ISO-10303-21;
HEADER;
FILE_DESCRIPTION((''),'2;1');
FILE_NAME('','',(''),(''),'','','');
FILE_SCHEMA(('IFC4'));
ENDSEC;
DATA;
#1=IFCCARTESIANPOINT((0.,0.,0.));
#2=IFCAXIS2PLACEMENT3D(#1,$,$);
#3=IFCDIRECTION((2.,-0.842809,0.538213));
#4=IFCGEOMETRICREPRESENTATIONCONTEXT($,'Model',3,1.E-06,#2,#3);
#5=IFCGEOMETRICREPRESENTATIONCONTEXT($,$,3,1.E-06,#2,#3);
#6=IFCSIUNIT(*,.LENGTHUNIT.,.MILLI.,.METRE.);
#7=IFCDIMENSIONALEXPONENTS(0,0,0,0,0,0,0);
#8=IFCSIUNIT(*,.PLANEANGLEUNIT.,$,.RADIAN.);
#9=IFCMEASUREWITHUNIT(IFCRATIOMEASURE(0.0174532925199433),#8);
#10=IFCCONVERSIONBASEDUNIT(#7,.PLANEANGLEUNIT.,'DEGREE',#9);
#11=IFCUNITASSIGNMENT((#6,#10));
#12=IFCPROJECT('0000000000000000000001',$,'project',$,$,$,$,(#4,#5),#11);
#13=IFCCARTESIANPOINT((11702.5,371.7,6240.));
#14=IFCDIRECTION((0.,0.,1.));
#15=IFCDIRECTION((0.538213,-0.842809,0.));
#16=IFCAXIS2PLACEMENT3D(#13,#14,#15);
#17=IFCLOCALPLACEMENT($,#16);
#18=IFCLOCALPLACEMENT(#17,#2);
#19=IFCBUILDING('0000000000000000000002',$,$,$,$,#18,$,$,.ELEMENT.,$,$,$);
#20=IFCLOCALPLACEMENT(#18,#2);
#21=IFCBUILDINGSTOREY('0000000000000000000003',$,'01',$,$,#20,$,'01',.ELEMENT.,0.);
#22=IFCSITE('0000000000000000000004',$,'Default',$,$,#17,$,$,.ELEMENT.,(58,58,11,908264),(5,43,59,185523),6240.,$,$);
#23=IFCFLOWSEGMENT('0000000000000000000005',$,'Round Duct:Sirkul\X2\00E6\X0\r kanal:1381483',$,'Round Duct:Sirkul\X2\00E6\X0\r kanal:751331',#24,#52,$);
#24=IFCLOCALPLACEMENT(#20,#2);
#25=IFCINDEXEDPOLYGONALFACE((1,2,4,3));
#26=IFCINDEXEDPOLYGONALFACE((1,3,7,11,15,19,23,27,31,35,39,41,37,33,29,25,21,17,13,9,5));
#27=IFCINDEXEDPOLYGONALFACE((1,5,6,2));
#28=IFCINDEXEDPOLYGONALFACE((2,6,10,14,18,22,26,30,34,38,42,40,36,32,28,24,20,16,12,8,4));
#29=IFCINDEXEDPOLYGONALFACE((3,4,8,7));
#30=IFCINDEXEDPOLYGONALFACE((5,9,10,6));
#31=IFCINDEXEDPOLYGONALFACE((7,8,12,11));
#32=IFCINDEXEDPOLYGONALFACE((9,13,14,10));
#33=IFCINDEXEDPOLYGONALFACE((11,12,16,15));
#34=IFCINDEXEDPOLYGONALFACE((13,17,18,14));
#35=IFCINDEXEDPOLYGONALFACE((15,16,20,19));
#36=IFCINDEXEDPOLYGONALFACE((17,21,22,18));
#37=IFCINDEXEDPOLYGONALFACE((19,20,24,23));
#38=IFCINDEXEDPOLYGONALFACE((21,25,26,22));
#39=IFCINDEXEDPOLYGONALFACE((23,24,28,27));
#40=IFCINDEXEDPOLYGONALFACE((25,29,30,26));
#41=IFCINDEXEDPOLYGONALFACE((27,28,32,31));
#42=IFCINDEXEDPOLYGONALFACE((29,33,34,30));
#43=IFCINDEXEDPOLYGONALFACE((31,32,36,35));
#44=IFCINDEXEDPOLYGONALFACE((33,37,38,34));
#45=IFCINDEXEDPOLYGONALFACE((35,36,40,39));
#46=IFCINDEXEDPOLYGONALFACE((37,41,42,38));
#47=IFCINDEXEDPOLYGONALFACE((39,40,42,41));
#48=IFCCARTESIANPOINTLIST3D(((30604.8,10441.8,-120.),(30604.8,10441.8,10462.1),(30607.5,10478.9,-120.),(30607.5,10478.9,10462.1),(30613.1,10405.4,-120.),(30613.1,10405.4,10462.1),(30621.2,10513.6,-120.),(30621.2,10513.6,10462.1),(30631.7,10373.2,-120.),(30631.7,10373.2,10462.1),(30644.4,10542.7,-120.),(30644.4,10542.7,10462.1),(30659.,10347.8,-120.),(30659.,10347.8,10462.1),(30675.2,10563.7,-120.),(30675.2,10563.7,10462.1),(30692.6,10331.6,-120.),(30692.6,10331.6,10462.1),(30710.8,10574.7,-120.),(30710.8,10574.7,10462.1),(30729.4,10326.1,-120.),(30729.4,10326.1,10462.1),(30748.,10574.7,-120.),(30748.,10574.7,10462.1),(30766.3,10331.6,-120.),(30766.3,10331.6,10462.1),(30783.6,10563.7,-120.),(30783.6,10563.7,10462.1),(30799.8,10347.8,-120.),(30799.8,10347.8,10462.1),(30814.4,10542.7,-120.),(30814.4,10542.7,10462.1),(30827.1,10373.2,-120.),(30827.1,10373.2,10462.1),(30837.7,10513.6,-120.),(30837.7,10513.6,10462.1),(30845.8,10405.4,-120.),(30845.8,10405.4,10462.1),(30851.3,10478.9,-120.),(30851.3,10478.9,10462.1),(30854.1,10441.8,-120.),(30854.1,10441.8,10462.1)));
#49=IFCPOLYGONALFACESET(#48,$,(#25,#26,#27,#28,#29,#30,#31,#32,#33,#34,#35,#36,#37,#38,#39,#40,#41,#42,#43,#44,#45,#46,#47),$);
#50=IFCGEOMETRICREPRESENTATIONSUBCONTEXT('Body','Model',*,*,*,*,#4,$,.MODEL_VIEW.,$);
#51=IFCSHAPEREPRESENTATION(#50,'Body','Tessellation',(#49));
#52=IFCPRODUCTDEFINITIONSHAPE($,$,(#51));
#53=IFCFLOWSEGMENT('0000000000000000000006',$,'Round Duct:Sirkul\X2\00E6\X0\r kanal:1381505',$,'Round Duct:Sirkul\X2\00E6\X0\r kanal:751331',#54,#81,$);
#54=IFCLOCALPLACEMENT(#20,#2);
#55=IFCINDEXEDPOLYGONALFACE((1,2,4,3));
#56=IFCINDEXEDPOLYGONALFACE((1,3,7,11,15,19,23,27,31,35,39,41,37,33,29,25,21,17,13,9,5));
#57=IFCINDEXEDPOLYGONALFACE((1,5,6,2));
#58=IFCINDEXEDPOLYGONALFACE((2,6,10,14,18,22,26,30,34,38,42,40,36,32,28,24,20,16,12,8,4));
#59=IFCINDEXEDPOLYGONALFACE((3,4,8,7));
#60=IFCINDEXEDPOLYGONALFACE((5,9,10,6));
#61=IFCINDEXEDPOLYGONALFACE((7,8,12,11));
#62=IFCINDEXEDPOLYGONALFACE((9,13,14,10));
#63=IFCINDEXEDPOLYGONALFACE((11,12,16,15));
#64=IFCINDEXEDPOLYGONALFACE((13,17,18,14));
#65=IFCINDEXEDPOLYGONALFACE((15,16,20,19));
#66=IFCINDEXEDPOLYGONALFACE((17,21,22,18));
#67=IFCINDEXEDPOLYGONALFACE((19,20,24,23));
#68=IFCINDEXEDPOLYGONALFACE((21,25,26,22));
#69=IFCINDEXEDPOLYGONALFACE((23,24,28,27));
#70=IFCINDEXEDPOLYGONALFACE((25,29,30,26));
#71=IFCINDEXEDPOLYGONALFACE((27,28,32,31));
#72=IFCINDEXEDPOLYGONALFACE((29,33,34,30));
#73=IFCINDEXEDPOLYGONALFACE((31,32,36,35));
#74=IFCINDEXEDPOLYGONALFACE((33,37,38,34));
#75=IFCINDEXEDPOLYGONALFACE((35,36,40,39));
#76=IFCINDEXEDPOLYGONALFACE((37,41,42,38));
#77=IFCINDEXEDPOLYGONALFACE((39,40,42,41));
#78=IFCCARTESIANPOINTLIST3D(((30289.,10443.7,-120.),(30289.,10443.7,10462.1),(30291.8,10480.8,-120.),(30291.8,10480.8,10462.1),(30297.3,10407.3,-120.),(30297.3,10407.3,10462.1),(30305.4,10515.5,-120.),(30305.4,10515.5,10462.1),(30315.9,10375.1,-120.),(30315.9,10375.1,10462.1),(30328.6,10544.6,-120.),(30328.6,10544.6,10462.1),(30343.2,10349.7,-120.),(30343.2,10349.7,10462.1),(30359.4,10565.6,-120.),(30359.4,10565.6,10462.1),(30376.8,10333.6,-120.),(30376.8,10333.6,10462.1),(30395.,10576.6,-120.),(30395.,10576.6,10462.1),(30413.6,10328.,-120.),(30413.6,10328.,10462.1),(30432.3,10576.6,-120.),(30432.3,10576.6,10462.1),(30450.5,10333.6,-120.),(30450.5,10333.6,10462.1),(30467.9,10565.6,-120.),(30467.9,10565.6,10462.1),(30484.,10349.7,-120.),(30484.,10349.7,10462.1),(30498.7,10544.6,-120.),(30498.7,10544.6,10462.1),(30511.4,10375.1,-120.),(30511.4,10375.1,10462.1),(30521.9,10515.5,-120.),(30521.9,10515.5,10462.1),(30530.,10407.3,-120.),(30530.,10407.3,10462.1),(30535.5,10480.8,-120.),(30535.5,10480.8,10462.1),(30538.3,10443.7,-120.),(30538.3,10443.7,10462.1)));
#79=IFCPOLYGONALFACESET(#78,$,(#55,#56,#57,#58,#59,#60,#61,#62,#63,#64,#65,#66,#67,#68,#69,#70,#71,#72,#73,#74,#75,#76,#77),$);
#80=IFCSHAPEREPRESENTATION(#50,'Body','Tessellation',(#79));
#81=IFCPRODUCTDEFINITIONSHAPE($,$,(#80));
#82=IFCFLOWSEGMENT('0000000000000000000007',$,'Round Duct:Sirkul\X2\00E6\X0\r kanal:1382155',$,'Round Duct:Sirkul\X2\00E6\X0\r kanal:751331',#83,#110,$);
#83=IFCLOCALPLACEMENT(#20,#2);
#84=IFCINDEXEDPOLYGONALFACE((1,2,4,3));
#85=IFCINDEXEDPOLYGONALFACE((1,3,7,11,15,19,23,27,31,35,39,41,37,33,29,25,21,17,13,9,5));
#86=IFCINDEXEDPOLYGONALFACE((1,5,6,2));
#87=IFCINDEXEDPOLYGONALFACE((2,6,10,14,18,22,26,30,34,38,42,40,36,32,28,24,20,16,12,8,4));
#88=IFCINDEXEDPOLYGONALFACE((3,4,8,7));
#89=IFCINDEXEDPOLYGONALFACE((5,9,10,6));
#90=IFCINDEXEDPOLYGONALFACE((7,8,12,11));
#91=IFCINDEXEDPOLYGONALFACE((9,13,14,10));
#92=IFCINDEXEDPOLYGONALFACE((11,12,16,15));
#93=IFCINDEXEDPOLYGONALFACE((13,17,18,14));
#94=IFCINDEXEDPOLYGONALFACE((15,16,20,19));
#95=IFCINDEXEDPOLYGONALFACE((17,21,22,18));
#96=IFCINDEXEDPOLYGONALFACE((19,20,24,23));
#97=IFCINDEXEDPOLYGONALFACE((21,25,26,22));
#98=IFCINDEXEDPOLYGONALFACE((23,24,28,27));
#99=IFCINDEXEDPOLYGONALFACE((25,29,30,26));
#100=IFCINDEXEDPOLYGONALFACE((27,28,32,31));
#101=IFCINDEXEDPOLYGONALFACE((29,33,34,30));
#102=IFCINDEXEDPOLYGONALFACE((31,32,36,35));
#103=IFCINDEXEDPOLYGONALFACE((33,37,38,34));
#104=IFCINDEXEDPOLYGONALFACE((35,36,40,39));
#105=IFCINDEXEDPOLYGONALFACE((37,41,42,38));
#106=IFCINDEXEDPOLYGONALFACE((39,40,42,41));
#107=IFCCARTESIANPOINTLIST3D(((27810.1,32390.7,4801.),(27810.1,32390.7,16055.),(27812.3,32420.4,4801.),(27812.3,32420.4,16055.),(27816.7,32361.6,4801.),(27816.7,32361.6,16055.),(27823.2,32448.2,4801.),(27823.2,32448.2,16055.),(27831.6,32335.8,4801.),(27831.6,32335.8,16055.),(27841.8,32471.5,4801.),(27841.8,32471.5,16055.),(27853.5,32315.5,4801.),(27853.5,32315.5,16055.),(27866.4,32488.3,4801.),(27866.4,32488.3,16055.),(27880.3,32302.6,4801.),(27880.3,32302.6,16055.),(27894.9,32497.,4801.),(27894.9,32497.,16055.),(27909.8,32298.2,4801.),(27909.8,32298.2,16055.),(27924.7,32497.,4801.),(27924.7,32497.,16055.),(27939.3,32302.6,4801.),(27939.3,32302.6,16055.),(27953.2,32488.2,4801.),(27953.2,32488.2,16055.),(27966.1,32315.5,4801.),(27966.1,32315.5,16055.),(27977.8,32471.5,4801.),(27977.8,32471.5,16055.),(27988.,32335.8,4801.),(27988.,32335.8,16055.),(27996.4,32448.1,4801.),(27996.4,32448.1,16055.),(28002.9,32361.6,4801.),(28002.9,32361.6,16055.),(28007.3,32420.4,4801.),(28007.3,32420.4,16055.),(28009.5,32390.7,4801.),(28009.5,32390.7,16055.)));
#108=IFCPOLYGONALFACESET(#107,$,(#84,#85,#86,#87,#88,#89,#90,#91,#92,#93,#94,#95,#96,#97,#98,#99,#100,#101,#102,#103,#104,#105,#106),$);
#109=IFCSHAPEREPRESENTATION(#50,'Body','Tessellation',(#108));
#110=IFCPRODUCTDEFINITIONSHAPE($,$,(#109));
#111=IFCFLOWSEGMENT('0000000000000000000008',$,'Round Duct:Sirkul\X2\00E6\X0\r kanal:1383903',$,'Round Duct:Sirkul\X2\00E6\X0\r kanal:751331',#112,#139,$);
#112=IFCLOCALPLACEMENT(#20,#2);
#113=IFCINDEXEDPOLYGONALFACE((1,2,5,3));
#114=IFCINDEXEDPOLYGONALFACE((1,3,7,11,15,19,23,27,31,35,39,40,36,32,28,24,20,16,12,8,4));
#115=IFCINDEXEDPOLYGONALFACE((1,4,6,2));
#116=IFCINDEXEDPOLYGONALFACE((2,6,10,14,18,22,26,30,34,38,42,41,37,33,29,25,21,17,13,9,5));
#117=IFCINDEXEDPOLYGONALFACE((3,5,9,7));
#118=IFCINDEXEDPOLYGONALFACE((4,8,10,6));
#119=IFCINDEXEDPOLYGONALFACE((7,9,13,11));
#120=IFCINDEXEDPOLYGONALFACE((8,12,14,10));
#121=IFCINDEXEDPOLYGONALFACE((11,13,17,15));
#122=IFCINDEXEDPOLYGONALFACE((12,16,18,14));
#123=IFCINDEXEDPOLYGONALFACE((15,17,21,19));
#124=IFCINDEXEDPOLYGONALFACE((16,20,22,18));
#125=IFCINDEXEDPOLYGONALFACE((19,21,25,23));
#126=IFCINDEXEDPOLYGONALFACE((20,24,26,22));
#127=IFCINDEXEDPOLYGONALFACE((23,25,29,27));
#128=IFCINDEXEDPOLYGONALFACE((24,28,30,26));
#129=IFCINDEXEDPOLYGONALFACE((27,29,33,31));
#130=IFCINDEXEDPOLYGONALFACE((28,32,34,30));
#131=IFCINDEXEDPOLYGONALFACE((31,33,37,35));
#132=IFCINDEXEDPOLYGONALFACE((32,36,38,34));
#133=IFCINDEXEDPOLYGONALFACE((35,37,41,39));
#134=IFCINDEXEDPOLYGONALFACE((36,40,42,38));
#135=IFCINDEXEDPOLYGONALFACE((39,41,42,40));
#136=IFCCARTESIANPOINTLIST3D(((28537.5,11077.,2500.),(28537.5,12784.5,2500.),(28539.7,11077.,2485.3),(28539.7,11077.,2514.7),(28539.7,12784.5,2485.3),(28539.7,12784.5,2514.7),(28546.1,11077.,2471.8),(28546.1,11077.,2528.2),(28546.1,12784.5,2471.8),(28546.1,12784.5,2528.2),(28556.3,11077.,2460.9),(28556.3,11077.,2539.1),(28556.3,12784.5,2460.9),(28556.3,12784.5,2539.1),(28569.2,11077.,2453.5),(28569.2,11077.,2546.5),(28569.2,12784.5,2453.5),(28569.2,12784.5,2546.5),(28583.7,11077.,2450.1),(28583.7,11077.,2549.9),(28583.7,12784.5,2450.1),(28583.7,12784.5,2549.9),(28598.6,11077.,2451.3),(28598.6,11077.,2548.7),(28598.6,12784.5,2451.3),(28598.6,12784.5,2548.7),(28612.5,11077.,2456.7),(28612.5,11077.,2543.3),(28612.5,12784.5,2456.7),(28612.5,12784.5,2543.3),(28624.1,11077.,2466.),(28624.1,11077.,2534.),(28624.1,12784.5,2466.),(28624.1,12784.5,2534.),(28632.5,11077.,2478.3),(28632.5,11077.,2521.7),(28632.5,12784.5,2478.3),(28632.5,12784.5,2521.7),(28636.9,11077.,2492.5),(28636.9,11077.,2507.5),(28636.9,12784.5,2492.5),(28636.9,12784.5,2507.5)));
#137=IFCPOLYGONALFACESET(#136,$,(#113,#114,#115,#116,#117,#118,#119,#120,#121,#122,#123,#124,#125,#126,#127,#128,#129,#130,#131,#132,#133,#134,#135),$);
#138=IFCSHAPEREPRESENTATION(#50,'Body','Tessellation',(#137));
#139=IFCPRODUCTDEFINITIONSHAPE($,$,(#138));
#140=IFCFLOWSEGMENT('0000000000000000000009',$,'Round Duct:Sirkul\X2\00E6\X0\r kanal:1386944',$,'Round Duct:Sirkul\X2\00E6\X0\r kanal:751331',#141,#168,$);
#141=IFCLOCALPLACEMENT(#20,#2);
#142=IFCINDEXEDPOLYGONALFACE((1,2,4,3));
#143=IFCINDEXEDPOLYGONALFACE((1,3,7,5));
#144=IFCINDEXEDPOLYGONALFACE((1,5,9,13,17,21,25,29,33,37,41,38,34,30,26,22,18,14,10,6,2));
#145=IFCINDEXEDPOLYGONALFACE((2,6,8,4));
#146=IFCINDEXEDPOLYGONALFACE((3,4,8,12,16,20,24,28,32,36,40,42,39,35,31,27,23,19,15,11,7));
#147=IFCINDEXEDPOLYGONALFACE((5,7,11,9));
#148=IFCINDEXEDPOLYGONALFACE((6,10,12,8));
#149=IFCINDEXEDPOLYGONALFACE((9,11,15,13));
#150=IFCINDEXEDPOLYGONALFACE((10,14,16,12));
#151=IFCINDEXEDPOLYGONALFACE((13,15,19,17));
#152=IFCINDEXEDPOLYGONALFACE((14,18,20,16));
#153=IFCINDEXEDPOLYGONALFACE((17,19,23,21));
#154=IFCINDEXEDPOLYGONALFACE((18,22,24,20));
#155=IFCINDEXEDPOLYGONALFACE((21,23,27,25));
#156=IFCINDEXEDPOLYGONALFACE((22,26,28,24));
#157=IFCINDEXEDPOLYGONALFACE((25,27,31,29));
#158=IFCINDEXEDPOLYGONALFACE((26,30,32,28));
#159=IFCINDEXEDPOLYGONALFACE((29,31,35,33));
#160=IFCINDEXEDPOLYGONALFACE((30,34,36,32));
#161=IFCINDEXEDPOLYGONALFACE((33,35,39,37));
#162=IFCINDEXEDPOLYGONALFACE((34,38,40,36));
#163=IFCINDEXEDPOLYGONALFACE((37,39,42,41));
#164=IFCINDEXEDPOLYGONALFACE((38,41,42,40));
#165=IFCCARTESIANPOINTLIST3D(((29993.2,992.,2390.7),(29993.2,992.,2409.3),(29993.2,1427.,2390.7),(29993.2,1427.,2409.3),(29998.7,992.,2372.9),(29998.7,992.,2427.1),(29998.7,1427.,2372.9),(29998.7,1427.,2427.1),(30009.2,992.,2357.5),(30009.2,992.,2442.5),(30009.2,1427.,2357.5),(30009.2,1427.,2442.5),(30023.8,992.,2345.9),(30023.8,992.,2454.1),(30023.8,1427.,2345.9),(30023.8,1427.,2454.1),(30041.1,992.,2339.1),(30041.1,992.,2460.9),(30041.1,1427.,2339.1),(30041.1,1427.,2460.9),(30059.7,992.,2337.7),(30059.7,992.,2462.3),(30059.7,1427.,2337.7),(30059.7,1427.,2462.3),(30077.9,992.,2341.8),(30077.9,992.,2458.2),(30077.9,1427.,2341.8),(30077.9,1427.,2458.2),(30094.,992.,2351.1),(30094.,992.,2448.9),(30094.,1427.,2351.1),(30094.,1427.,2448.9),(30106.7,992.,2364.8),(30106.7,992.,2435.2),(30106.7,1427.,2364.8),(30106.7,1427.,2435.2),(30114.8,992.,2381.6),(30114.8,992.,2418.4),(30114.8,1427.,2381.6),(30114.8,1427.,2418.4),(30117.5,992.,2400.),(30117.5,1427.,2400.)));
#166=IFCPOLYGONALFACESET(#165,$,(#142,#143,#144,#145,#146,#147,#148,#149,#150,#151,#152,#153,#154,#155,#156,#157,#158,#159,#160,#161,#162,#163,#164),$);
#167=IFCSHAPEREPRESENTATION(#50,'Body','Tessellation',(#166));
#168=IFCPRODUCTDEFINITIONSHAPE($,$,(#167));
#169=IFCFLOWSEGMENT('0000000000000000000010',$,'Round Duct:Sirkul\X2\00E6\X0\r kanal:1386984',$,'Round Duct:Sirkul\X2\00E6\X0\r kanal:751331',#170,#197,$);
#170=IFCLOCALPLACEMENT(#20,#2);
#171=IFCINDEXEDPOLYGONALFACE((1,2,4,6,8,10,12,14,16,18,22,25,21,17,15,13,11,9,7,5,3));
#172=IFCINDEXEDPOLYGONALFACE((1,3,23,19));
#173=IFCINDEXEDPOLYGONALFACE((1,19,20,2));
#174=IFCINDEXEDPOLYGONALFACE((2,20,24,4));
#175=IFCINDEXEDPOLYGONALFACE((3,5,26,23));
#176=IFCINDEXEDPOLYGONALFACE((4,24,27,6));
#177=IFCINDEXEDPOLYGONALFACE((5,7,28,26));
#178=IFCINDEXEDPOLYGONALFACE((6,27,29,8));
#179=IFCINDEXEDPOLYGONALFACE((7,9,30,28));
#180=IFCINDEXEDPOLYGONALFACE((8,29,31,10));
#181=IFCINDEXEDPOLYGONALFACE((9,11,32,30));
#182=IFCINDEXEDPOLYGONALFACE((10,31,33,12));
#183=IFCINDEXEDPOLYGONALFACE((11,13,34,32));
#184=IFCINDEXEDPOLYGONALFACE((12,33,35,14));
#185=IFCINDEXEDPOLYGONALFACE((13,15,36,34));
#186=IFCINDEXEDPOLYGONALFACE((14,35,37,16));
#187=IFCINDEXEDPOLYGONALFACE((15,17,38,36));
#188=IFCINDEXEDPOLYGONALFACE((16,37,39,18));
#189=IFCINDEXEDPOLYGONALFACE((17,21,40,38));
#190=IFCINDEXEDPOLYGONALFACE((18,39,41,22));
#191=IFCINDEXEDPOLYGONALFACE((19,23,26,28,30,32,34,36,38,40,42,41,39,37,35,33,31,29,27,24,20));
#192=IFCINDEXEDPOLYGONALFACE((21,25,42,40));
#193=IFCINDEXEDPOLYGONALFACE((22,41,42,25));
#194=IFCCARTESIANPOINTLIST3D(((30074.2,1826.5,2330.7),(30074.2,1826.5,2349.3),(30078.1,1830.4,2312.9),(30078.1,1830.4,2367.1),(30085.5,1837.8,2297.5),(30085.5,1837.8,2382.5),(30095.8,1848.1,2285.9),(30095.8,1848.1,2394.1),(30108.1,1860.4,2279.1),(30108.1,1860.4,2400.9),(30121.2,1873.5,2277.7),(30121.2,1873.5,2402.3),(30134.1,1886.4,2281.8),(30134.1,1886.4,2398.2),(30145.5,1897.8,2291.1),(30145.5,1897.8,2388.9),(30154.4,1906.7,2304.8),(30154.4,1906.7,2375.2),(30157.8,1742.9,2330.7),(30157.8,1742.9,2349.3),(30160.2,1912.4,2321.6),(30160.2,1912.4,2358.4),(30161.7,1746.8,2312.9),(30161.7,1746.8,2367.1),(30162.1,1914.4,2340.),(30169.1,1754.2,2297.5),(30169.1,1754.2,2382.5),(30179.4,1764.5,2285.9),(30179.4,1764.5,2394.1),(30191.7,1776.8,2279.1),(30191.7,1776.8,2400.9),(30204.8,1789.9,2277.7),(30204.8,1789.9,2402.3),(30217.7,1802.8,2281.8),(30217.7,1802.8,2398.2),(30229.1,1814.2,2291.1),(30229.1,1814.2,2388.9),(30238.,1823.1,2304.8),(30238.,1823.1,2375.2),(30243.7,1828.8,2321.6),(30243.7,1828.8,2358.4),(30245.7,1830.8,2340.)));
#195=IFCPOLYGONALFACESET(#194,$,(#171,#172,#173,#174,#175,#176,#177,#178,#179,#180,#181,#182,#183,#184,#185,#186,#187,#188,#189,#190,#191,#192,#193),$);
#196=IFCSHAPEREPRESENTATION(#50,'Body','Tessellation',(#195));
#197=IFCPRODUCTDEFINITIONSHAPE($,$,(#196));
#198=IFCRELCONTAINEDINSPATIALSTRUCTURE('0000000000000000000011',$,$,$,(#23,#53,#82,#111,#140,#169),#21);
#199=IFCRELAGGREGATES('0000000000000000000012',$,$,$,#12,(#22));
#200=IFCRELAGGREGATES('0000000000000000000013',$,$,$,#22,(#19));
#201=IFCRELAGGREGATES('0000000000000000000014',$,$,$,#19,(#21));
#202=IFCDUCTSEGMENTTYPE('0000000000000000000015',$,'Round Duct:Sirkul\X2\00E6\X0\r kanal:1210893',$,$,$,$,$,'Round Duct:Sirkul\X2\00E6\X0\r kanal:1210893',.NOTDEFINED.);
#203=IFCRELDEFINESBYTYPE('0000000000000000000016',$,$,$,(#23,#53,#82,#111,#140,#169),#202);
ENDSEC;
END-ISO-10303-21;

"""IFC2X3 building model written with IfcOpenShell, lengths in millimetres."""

from ifc_helpers import new_model, entity, si_unit, converted_unit, direction, frame, frame_2d, origin, origin_2d_with_axis, place, context, subcontext, project, spatial, circle, extrude, type_object, element, save


model = new_model("IFC2X3")

# Units and contexts
model_context = context("Model", 3, precision=1e-06, world=origin(), true_north=direction((2.0, -0.842809, 0.538213)))
context_of_model = context(None, 3, precision=1e-06, world=origin(), true_north=direction((2.0, -0.842809, 0.538213)))
body_context = subcontext(model_context, "Body", "Model", "MODEL_VIEW")
ifc_project = project(units=[si_unit("LENGTHUNIT", "METRE", prefix="MILLI"), converted_unit("PLANEANGLEUNIT", "DEGREE", entity("IfcRatioMeasure", 0.0174532925199433), si_unit("PLANEANGLEUNIT", "RADIAN"), dimensions=[0, 0, 0, 0, 0, 0, 0])], contexts=[model_context, context_of_model])

# Site, building, storey
site_placement = place(None, frame((11702.5, 371.7, 6240.0), z_axis=(0.0, 0.0, 1.0), x_axis=(0.538213, -0.842809, 0.0)))
site = spatial("IfcSite", under=ifc_project, at=site_placement, Name="Default", CompositionType="ELEMENT", RefLatitude=(58, 58, 11, 908264), RefLongitude=(5, 43, 59, 185523), RefElevation=6240.0)
building_placement = place(site_placement, origin())
building = spatial("IfcBuilding", under=site, at=building_placement, CompositionType="ELEMENT")
storey_placement = place(building_placement, origin())
storey = spatial("IfcBuildingStorey", under=building, at=storey_placement, Name="01", LongName="01", CompositionType="ELEMENT", Elevation=0.0)

# Flow segments
duct_segment_type_1 = type_object("IfcDuctSegmentType", Name="Round Duct:Sirkulær kanal:1210893", ElementType="Round Duct:Sirkulær kanal:1210893", PredefinedType="NOTDEFINED")
flow_segment_1_placement = place(storey_placement, origin())
element("IfcFlowSegment", 1, at=flow_segment_1_placement, inside=storey, type_object=duct_segment_type_1, Name="Round Duct:Sirkulær kanal:1381483", ObjectType="Round Duct:Sirkulær kanal:751331", context=body_context, shape_type="SweptSolid", body=[
    extrude(circle(Radius=125.0, at=frame_2d((0.0, 0.0), x_axis=(1.0, 0.0))), frame((30729.4, 10451.1, -120.0), z_axis=(0.0, 0.0, 1.0), x_axis=(0.0, -1.0, 0.0)), (0.0, 0.0, 1.0), 10582.1),
])
flow_segment_2_placement = place(storey_placement, origin())
element("IfcFlowSegment", 2, at=flow_segment_2_placement, inside=storey, type_object=duct_segment_type_1, Name="Round Duct:Sirkulær kanal:1381505", ObjectType="Round Duct:Sirkulær kanal:751331", context=body_context, shape_type="SweptSolid", body=[
    extrude(circle(Radius=125.0, at=frame_2d((0.0, 0.0), x_axis=(1.0, 0.0))), frame((30413.6, 10453.0, -120.0), z_axis=(0.0, 0.0, 1.0), x_axis=(0.0, -1.0, 0.0)), (0.0, 0.0, 1.0), 10582.1),
])
flow_segment_3_placement = place(storey_placement, origin())
element("IfcFlowSegment", 3, at=flow_segment_3_placement, inside=storey, type_object=duct_segment_type_1, Name="Round Duct:Sirkulær kanal:1382155", ObjectType="Round Duct:Sirkulær kanal:751331", context=body_context, shape_type="SweptSolid", body=[
    extrude(circle(Radius=100.0, at=origin_2d_with_axis()), frame((27909.8, 32398.2, 4801.0), z_axis=(0.0, 0.0, 1.0), x_axis=(-0.000073, -1.0, 0.0)), (0.0, 0.0, 1.0), 11254.0),
])
flow_segment_4_placement = place(storey_placement, origin())
element("IfcFlowSegment", 4, at=flow_segment_4_placement, inside=storey, type_object=duct_segment_type_1, Name="Round Duct:Sirkulær kanal:1383903", ObjectType="Round Duct:Sirkulær kanal:751331", context=body_context, shape_type="SweptSolid", body=[
    extrude(circle(Radius=50.0, at=frame_2d((0.0, 0.0), x_axis=(1.0, 0.0))), frame((28587.5, 11077.0, 2500.0), z_axis=(0.0, 1.0, 0.0), x_axis=(-1.0, 0.0, 0.0)), (0.0, 0.0, 1.0), 1707.5),
])
flow_segment_5_placement = place(storey_placement, origin())
element("IfcFlowSegment", 5, at=flow_segment_5_placement, inside=storey, type_object=duct_segment_type_1, Name="Round Duct:Sirkulær kanal:1386944", ObjectType="Round Duct:Sirkulær kanal:751331", context=body_context, shape_type="SweptSolid", body=[
    extrude(circle(Radius=62.5, at=origin_2d_with_axis()), frame((30055.0, 992.0, 2400.0), z_axis=(0.0, 1.0, 0.0), x_axis=(1.0, 0.0, 0.0)), (0.0, 0.0, 1.0), 435.0),
])
flow_segment_6_placement = place(storey_placement, origin())
element("IfcFlowSegment", 6, at=flow_segment_6_placement, inside=storey, type_object=duct_segment_type_1, Name="Round Duct:Sirkulær kanal:1386984", ObjectType="Round Duct:Sirkulær kanal:751331", context=body_context, shape_type="SweptSolid", body=[
    extrude(circle(Radius=62.5, at=frame_2d((0.0, 0.0), x_axis=(1.0, 0.0))), frame((30201.5, 1786.6, 2340.0), z_axis=(-0.707107, 0.707107, 0.0), x_axis=(0.707107, 0.707107, 0.0)), (0.0, 0.0, 1.0), 118.2),
])

save(model, "model.ifc")
